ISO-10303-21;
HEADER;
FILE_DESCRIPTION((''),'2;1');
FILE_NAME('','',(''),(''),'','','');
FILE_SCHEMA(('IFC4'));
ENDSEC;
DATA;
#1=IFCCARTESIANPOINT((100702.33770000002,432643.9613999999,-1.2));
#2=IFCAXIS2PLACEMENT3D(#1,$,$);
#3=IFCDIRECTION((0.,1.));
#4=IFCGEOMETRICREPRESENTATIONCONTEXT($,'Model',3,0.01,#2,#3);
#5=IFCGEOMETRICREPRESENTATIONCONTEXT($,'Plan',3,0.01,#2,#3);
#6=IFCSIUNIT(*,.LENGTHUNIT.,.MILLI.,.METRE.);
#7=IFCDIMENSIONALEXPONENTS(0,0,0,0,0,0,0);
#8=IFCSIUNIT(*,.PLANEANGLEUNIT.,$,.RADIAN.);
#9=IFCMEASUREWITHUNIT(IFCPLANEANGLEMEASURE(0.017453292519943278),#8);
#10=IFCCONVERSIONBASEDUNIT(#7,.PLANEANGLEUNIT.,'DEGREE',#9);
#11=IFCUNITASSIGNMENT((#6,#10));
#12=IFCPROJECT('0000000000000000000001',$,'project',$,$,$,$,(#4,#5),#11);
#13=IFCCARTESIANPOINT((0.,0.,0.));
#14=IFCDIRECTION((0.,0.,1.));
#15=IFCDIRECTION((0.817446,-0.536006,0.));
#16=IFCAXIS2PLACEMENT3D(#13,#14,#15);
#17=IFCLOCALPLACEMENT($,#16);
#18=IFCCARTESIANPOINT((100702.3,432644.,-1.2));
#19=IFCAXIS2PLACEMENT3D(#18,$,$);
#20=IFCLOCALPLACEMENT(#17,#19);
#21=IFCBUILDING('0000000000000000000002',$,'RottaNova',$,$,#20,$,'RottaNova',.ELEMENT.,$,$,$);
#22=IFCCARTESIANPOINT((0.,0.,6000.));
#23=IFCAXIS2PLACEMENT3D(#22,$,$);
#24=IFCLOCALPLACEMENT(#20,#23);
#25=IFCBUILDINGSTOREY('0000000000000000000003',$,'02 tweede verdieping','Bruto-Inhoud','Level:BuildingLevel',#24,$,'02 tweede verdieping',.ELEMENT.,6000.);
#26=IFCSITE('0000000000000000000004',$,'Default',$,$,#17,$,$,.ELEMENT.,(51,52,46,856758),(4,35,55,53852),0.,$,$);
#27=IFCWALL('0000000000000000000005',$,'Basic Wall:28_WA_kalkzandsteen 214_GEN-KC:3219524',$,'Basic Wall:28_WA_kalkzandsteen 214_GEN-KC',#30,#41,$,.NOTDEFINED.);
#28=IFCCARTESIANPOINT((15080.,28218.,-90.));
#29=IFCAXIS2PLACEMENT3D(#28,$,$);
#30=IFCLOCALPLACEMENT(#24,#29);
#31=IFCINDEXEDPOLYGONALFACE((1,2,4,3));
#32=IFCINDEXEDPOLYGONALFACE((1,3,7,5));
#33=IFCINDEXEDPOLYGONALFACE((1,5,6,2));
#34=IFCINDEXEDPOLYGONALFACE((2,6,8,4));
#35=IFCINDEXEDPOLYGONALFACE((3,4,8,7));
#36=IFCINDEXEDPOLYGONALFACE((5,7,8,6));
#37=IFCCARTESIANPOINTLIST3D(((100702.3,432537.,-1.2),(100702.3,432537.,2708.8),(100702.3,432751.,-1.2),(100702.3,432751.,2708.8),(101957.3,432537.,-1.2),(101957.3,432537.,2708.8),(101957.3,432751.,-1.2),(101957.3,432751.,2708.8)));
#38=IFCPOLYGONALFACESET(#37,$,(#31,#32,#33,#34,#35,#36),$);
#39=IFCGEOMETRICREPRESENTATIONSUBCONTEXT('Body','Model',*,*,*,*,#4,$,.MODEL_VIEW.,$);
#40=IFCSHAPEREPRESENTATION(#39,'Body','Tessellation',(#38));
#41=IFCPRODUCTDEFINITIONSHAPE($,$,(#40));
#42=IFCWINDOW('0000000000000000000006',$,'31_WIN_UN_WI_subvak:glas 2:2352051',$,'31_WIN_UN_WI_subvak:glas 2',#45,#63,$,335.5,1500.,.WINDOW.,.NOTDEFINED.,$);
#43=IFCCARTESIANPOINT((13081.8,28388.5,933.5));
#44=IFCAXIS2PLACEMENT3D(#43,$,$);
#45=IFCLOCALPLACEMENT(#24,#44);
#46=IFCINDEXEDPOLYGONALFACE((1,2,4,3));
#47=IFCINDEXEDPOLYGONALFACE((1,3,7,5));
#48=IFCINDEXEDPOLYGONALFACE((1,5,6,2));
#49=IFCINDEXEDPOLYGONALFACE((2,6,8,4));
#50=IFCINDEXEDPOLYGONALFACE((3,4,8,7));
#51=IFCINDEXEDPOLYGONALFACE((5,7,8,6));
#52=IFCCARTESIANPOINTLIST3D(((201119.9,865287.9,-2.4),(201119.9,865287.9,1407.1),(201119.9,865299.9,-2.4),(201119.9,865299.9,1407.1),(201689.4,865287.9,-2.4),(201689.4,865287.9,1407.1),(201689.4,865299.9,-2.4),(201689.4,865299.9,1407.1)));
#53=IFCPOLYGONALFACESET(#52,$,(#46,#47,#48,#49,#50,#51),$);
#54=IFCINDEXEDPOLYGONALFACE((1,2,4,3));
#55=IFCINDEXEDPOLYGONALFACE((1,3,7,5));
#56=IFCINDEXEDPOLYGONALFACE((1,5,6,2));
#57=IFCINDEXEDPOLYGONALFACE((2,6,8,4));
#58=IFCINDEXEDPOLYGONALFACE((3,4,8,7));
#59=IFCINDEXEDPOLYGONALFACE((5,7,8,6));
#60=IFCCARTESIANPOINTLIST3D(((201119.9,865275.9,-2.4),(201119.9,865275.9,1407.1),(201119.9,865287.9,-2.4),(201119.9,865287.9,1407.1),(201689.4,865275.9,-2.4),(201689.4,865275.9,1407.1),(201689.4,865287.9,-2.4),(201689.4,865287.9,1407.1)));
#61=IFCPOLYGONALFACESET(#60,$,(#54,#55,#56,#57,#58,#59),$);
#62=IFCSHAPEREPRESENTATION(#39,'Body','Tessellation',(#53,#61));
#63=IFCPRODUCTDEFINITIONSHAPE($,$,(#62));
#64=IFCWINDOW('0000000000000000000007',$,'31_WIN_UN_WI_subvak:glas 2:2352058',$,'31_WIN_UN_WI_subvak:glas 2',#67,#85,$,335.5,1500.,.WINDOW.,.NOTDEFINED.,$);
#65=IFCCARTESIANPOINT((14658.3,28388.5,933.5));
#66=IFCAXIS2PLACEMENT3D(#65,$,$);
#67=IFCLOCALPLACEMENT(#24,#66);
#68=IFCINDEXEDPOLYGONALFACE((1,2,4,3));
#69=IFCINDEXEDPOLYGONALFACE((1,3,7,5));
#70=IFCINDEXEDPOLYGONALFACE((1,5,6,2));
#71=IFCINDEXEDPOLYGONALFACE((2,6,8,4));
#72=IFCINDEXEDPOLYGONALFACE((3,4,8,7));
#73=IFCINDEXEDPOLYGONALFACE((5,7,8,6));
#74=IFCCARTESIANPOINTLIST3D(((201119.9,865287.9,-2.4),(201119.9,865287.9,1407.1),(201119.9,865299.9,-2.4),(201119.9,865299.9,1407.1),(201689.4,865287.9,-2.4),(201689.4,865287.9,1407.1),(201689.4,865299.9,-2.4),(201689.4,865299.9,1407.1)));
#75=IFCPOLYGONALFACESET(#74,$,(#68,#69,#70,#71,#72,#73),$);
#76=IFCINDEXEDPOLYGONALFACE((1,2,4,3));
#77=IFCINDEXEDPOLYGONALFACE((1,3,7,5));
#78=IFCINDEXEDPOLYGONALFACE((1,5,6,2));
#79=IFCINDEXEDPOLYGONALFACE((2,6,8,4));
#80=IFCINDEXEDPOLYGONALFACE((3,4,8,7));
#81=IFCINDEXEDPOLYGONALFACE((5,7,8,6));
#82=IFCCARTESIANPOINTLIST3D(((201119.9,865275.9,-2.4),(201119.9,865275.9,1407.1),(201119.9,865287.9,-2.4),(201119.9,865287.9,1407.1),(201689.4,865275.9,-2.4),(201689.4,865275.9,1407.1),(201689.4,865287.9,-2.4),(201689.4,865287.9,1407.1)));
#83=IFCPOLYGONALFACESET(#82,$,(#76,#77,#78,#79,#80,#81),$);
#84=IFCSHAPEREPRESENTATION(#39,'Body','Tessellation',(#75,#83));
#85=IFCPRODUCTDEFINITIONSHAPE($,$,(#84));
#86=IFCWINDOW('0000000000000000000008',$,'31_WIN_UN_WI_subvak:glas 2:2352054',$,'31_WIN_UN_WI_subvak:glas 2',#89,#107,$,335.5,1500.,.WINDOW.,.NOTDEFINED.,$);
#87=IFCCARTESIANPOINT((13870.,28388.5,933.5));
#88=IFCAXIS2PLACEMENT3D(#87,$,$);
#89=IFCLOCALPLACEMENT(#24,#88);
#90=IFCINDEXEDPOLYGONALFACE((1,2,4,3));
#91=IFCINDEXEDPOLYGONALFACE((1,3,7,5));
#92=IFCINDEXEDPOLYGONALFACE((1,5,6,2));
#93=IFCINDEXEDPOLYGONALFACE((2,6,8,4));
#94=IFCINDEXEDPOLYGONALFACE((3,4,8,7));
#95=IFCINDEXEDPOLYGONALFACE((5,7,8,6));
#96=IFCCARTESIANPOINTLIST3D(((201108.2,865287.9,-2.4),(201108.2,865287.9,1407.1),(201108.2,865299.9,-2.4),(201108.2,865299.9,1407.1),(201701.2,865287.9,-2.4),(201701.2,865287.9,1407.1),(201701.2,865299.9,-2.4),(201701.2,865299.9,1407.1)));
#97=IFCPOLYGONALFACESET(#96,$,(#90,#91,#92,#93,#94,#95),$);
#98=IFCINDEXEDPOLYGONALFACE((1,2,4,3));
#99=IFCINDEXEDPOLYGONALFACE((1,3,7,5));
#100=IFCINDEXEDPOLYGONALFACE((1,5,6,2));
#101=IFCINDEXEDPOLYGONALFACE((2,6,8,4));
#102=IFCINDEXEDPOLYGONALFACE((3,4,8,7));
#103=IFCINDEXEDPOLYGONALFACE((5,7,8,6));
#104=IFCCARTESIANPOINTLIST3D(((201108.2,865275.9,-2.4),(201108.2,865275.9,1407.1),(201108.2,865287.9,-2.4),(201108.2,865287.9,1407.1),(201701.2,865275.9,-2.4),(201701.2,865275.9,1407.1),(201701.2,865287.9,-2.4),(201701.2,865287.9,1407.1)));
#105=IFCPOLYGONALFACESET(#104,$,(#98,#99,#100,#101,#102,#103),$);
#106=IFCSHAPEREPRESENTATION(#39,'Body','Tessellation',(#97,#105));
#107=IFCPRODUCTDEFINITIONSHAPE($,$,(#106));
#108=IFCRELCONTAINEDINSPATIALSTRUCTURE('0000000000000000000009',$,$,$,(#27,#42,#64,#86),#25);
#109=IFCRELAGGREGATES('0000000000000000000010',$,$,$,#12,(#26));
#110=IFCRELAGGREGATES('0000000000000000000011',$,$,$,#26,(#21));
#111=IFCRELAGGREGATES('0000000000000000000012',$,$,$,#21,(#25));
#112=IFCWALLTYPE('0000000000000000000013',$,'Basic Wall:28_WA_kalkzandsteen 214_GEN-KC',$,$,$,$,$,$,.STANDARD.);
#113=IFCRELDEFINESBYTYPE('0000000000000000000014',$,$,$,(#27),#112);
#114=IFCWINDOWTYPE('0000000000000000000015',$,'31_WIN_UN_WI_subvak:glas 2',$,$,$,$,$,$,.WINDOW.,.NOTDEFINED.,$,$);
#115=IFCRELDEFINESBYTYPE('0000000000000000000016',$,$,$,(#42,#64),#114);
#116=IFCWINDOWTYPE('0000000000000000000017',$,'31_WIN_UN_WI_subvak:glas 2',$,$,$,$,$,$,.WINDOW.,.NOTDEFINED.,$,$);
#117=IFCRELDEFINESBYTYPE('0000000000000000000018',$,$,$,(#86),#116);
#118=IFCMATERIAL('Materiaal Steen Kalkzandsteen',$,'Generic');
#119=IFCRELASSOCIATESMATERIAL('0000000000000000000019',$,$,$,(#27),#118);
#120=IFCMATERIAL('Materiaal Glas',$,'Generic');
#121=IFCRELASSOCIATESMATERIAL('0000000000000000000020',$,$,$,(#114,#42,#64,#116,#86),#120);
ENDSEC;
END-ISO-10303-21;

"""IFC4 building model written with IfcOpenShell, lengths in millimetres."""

from ifc_helpers import new_model, entity, si_unit, converted_unit, direction, frame, place, context, subcontext, project, spatial, indexed_curve, outline, extrude, source, transform, mapped, material, type_object, type_shapes, element, save


model = new_model("IFC4")

# Units and contexts
model_context = context("Model", 3, precision=0.01, world=frame((100702.33770000002, 432643.9613999999, -1.2)), true_north=direction((0.0, 1.0)))
plan_context = context("Plan", 3, precision=0.01, world=frame((100702.33770000002, 432643.9613999999, -1.2)), true_north=direction((0.0, 1.0)))
body_context = subcontext(model_context, "Body", "Model", "MODEL_VIEW")
ifc_project = project(units=[si_unit("LENGTHUNIT", "METRE", prefix="MILLI"), converted_unit("PLANEANGLEUNIT", "DEGREE", entity("IfcPlaneAngleMeasure", 0.017453292519943278), si_unit("PLANEANGLEUNIT", "RADIAN"), dimensions=[0, 0, 0, 0, 0, 0, 0])], contexts=[model_context, plan_context])

# Site, building, storey
site_placement = place(None, frame((0.0, 0.0, 0.0), z_axis=(0.0, 0.0, 1.0), x_axis=(0.817446, -0.536006, 0.0)))
site = spatial("IfcSite", under=ifc_project, at=site_placement, Name="Default", CompositionType="ELEMENT", RefLatitude=(51, 52, 46, 856758), RefLongitude=(4, 35, 55, 53852), RefElevation=0.0)
building_placement = place(site_placement, frame((100702.3, 432644.0, -1.2)))
building = spatial("IfcBuilding", under=site, at=building_placement, Name="RottaNova", LongName="RottaNova", CompositionType="ELEMENT")
storey_placement = place(building_placement, frame((0.0, 0.0, 6000.0)))
storey = spatial("IfcBuildingStorey", under=building, at=storey_placement, Name="02 tweede verdieping", Description="Bruto-Inhoud", ObjectType="Level:BuildingLevel", LongName="02 tweede verdieping", CompositionType="ELEMENT", Elevation=6000.0)

# Shared definitions
ifc_material_1 = material(Name="Materiaal Glas", Category="Generic")

# Wall
ifc_material_2 = material(Name="Materiaal Steen Kalkzandsteen", Category="Generic")
wall_type = type_object("IfcWallType", Name="Basic Wall:28_WA_kalkzandsteen 214_GEN-KC", PredefinedType="STANDARD")
wall_placement = place(storey_placement, frame((15080.0, 28218.0, -90.0)))
element("IfcWall", 1, at=wall_placement, inside=storey, type_object=wall_type, material=ifc_material_2, Name="Basic Wall:28_WA_kalkzandsteen 214_GEN-KC:3219524", ObjectType="Basic Wall:28_WA_kalkzandsteen 214_GEN-KC", PredefinedType="NOTDEFINED", context=body_context, shape_type="SweptSolid", body=[
    extrude(outline(indexed_curve([(1255.0, 107.0), (0.0, 107.0), (0.0, -107.0), (1255.0, -107.0), (1255.0, 107.0)], self_intersect=False)), frame((100702.3, 432644.0, -1.2)), (0.0, 0.0, 1.0), 2710.0),
])

# Windows
window_type_1 = type_object("IfcWindowType", Name="31_WIN_UN_WI_subvak:glas 2", PartitioningType="NOTDEFINED", PredefinedType="WINDOW", material=ifc_material_1)
shared_shape_1 = source(frame((100702.3, 432644.0, -1.2)), body_context, "Body", "SweptSolid", [
    extrude(outline(indexed_curve([(-6.0, -284.7), (6.0, -284.7), (6.0, 284.7), (-6.0, 284.7), (-6.0, -284.7)], self_intersect=False)), frame((0.0, 6.0, 0.0), z_axis=(0.0, 0.0, 1.0), x_axis=(0.0, -1.0, 0.0)), (0.0, 0.0, 1.0), 1409.5),
    extrude(outline(indexed_curve([(-6.0, -284.8), (6.0, -284.8), (6.0, 284.8), (-6.0, 284.8), (-6.0, -284.8)], self_intersect=False)), frame((0.0, -6.0, 0.0), z_axis=(0.0, 0.0, 1.0), x_axis=(0.0, -1.0, 0.0)), (0.0, 0.0, 1.0), 1409.5),
])
type_shapes(window_type_1, [shared_shape_1])
for number, where, name in (
    (2, (13081.8, 28388.5, 933.5), "31_WIN_UN_WI_subvak:glas 2:2352051"),
    (3, (14658.3, 28388.5, 933.5), "31_WIN_UN_WI_subvak:glas 2:2352058"),
):
    element("IfcWindow", number, at=place(storey_placement, frame(where)), inside=storey, type_object=window_type_1, material=ifc_material_1, Name=name, ObjectType="31_WIN_UN_WI_subvak:glas 2", OverallHeight=335.5, OverallWidth=1500.0, PartitioningType="NOTDEFINED", PredefinedType="WINDOW", context=body_context, shape_type="MappedRepresentation", body=[
        mapped(shared_shape_1, transform((100702.3, 432644.0, -1.2), scale=1.0)),
    ])
window_type_2 = type_object("IfcWindowType", Name="31_WIN_UN_WI_subvak:glas 2", PartitioningType="NOTDEFINED", PredefinedType="WINDOW", material=ifc_material_1)
shared_shape_2 = source(frame((100702.3, 432644.0, -1.2)), body_context, "Body", "SweptSolid", [
    extrude(outline(indexed_curve([(-6.0, -296.5), (6.0, -296.5), (6.0, 296.5), (-6.0, 296.5), (-6.0, -296.5)], self_intersect=False)), frame((0.0, 6.0, 0.0), z_axis=(0.0, 0.0, 1.0), x_axis=(0.0, -1.0, 0.0)), (0.0, 0.0, 1.0), 1409.5),
    extrude(outline(indexed_curve([(-6.0, -296.5), (6.0, -296.5), (6.0, 296.5), (-6.0, 296.5), (-6.0, -296.5)], self_intersect=False)), frame((0.0, -6.0, 0.0), z_axis=(0.0, 0.0, 1.0), x_axis=(0.0, -1.0, 0.0)), (0.0, 0.0, 1.0), 1409.5),
])
type_shapes(window_type_2, [shared_shape_2])
window_1_placement = place(storey_placement, frame((13870.0, 28388.5, 933.5)))
element("IfcWindow", 4, at=window_1_placement, inside=storey, type_object=window_type_2, material=ifc_material_1, Name="31_WIN_UN_WI_subvak:glas 2:2352054", ObjectType="31_WIN_UN_WI_subvak:glas 2", OverallHeight=335.5, OverallWidth=1500.0, PartitioningType="NOTDEFINED", PredefinedType="WINDOW", context=body_context, shape_type="MappedRepresentation", body=[
    mapped(shared_shape_2, transform((100702.3, 432644.0, -1.2), scale=1.0)),
])

save(model, "model.ifc")
